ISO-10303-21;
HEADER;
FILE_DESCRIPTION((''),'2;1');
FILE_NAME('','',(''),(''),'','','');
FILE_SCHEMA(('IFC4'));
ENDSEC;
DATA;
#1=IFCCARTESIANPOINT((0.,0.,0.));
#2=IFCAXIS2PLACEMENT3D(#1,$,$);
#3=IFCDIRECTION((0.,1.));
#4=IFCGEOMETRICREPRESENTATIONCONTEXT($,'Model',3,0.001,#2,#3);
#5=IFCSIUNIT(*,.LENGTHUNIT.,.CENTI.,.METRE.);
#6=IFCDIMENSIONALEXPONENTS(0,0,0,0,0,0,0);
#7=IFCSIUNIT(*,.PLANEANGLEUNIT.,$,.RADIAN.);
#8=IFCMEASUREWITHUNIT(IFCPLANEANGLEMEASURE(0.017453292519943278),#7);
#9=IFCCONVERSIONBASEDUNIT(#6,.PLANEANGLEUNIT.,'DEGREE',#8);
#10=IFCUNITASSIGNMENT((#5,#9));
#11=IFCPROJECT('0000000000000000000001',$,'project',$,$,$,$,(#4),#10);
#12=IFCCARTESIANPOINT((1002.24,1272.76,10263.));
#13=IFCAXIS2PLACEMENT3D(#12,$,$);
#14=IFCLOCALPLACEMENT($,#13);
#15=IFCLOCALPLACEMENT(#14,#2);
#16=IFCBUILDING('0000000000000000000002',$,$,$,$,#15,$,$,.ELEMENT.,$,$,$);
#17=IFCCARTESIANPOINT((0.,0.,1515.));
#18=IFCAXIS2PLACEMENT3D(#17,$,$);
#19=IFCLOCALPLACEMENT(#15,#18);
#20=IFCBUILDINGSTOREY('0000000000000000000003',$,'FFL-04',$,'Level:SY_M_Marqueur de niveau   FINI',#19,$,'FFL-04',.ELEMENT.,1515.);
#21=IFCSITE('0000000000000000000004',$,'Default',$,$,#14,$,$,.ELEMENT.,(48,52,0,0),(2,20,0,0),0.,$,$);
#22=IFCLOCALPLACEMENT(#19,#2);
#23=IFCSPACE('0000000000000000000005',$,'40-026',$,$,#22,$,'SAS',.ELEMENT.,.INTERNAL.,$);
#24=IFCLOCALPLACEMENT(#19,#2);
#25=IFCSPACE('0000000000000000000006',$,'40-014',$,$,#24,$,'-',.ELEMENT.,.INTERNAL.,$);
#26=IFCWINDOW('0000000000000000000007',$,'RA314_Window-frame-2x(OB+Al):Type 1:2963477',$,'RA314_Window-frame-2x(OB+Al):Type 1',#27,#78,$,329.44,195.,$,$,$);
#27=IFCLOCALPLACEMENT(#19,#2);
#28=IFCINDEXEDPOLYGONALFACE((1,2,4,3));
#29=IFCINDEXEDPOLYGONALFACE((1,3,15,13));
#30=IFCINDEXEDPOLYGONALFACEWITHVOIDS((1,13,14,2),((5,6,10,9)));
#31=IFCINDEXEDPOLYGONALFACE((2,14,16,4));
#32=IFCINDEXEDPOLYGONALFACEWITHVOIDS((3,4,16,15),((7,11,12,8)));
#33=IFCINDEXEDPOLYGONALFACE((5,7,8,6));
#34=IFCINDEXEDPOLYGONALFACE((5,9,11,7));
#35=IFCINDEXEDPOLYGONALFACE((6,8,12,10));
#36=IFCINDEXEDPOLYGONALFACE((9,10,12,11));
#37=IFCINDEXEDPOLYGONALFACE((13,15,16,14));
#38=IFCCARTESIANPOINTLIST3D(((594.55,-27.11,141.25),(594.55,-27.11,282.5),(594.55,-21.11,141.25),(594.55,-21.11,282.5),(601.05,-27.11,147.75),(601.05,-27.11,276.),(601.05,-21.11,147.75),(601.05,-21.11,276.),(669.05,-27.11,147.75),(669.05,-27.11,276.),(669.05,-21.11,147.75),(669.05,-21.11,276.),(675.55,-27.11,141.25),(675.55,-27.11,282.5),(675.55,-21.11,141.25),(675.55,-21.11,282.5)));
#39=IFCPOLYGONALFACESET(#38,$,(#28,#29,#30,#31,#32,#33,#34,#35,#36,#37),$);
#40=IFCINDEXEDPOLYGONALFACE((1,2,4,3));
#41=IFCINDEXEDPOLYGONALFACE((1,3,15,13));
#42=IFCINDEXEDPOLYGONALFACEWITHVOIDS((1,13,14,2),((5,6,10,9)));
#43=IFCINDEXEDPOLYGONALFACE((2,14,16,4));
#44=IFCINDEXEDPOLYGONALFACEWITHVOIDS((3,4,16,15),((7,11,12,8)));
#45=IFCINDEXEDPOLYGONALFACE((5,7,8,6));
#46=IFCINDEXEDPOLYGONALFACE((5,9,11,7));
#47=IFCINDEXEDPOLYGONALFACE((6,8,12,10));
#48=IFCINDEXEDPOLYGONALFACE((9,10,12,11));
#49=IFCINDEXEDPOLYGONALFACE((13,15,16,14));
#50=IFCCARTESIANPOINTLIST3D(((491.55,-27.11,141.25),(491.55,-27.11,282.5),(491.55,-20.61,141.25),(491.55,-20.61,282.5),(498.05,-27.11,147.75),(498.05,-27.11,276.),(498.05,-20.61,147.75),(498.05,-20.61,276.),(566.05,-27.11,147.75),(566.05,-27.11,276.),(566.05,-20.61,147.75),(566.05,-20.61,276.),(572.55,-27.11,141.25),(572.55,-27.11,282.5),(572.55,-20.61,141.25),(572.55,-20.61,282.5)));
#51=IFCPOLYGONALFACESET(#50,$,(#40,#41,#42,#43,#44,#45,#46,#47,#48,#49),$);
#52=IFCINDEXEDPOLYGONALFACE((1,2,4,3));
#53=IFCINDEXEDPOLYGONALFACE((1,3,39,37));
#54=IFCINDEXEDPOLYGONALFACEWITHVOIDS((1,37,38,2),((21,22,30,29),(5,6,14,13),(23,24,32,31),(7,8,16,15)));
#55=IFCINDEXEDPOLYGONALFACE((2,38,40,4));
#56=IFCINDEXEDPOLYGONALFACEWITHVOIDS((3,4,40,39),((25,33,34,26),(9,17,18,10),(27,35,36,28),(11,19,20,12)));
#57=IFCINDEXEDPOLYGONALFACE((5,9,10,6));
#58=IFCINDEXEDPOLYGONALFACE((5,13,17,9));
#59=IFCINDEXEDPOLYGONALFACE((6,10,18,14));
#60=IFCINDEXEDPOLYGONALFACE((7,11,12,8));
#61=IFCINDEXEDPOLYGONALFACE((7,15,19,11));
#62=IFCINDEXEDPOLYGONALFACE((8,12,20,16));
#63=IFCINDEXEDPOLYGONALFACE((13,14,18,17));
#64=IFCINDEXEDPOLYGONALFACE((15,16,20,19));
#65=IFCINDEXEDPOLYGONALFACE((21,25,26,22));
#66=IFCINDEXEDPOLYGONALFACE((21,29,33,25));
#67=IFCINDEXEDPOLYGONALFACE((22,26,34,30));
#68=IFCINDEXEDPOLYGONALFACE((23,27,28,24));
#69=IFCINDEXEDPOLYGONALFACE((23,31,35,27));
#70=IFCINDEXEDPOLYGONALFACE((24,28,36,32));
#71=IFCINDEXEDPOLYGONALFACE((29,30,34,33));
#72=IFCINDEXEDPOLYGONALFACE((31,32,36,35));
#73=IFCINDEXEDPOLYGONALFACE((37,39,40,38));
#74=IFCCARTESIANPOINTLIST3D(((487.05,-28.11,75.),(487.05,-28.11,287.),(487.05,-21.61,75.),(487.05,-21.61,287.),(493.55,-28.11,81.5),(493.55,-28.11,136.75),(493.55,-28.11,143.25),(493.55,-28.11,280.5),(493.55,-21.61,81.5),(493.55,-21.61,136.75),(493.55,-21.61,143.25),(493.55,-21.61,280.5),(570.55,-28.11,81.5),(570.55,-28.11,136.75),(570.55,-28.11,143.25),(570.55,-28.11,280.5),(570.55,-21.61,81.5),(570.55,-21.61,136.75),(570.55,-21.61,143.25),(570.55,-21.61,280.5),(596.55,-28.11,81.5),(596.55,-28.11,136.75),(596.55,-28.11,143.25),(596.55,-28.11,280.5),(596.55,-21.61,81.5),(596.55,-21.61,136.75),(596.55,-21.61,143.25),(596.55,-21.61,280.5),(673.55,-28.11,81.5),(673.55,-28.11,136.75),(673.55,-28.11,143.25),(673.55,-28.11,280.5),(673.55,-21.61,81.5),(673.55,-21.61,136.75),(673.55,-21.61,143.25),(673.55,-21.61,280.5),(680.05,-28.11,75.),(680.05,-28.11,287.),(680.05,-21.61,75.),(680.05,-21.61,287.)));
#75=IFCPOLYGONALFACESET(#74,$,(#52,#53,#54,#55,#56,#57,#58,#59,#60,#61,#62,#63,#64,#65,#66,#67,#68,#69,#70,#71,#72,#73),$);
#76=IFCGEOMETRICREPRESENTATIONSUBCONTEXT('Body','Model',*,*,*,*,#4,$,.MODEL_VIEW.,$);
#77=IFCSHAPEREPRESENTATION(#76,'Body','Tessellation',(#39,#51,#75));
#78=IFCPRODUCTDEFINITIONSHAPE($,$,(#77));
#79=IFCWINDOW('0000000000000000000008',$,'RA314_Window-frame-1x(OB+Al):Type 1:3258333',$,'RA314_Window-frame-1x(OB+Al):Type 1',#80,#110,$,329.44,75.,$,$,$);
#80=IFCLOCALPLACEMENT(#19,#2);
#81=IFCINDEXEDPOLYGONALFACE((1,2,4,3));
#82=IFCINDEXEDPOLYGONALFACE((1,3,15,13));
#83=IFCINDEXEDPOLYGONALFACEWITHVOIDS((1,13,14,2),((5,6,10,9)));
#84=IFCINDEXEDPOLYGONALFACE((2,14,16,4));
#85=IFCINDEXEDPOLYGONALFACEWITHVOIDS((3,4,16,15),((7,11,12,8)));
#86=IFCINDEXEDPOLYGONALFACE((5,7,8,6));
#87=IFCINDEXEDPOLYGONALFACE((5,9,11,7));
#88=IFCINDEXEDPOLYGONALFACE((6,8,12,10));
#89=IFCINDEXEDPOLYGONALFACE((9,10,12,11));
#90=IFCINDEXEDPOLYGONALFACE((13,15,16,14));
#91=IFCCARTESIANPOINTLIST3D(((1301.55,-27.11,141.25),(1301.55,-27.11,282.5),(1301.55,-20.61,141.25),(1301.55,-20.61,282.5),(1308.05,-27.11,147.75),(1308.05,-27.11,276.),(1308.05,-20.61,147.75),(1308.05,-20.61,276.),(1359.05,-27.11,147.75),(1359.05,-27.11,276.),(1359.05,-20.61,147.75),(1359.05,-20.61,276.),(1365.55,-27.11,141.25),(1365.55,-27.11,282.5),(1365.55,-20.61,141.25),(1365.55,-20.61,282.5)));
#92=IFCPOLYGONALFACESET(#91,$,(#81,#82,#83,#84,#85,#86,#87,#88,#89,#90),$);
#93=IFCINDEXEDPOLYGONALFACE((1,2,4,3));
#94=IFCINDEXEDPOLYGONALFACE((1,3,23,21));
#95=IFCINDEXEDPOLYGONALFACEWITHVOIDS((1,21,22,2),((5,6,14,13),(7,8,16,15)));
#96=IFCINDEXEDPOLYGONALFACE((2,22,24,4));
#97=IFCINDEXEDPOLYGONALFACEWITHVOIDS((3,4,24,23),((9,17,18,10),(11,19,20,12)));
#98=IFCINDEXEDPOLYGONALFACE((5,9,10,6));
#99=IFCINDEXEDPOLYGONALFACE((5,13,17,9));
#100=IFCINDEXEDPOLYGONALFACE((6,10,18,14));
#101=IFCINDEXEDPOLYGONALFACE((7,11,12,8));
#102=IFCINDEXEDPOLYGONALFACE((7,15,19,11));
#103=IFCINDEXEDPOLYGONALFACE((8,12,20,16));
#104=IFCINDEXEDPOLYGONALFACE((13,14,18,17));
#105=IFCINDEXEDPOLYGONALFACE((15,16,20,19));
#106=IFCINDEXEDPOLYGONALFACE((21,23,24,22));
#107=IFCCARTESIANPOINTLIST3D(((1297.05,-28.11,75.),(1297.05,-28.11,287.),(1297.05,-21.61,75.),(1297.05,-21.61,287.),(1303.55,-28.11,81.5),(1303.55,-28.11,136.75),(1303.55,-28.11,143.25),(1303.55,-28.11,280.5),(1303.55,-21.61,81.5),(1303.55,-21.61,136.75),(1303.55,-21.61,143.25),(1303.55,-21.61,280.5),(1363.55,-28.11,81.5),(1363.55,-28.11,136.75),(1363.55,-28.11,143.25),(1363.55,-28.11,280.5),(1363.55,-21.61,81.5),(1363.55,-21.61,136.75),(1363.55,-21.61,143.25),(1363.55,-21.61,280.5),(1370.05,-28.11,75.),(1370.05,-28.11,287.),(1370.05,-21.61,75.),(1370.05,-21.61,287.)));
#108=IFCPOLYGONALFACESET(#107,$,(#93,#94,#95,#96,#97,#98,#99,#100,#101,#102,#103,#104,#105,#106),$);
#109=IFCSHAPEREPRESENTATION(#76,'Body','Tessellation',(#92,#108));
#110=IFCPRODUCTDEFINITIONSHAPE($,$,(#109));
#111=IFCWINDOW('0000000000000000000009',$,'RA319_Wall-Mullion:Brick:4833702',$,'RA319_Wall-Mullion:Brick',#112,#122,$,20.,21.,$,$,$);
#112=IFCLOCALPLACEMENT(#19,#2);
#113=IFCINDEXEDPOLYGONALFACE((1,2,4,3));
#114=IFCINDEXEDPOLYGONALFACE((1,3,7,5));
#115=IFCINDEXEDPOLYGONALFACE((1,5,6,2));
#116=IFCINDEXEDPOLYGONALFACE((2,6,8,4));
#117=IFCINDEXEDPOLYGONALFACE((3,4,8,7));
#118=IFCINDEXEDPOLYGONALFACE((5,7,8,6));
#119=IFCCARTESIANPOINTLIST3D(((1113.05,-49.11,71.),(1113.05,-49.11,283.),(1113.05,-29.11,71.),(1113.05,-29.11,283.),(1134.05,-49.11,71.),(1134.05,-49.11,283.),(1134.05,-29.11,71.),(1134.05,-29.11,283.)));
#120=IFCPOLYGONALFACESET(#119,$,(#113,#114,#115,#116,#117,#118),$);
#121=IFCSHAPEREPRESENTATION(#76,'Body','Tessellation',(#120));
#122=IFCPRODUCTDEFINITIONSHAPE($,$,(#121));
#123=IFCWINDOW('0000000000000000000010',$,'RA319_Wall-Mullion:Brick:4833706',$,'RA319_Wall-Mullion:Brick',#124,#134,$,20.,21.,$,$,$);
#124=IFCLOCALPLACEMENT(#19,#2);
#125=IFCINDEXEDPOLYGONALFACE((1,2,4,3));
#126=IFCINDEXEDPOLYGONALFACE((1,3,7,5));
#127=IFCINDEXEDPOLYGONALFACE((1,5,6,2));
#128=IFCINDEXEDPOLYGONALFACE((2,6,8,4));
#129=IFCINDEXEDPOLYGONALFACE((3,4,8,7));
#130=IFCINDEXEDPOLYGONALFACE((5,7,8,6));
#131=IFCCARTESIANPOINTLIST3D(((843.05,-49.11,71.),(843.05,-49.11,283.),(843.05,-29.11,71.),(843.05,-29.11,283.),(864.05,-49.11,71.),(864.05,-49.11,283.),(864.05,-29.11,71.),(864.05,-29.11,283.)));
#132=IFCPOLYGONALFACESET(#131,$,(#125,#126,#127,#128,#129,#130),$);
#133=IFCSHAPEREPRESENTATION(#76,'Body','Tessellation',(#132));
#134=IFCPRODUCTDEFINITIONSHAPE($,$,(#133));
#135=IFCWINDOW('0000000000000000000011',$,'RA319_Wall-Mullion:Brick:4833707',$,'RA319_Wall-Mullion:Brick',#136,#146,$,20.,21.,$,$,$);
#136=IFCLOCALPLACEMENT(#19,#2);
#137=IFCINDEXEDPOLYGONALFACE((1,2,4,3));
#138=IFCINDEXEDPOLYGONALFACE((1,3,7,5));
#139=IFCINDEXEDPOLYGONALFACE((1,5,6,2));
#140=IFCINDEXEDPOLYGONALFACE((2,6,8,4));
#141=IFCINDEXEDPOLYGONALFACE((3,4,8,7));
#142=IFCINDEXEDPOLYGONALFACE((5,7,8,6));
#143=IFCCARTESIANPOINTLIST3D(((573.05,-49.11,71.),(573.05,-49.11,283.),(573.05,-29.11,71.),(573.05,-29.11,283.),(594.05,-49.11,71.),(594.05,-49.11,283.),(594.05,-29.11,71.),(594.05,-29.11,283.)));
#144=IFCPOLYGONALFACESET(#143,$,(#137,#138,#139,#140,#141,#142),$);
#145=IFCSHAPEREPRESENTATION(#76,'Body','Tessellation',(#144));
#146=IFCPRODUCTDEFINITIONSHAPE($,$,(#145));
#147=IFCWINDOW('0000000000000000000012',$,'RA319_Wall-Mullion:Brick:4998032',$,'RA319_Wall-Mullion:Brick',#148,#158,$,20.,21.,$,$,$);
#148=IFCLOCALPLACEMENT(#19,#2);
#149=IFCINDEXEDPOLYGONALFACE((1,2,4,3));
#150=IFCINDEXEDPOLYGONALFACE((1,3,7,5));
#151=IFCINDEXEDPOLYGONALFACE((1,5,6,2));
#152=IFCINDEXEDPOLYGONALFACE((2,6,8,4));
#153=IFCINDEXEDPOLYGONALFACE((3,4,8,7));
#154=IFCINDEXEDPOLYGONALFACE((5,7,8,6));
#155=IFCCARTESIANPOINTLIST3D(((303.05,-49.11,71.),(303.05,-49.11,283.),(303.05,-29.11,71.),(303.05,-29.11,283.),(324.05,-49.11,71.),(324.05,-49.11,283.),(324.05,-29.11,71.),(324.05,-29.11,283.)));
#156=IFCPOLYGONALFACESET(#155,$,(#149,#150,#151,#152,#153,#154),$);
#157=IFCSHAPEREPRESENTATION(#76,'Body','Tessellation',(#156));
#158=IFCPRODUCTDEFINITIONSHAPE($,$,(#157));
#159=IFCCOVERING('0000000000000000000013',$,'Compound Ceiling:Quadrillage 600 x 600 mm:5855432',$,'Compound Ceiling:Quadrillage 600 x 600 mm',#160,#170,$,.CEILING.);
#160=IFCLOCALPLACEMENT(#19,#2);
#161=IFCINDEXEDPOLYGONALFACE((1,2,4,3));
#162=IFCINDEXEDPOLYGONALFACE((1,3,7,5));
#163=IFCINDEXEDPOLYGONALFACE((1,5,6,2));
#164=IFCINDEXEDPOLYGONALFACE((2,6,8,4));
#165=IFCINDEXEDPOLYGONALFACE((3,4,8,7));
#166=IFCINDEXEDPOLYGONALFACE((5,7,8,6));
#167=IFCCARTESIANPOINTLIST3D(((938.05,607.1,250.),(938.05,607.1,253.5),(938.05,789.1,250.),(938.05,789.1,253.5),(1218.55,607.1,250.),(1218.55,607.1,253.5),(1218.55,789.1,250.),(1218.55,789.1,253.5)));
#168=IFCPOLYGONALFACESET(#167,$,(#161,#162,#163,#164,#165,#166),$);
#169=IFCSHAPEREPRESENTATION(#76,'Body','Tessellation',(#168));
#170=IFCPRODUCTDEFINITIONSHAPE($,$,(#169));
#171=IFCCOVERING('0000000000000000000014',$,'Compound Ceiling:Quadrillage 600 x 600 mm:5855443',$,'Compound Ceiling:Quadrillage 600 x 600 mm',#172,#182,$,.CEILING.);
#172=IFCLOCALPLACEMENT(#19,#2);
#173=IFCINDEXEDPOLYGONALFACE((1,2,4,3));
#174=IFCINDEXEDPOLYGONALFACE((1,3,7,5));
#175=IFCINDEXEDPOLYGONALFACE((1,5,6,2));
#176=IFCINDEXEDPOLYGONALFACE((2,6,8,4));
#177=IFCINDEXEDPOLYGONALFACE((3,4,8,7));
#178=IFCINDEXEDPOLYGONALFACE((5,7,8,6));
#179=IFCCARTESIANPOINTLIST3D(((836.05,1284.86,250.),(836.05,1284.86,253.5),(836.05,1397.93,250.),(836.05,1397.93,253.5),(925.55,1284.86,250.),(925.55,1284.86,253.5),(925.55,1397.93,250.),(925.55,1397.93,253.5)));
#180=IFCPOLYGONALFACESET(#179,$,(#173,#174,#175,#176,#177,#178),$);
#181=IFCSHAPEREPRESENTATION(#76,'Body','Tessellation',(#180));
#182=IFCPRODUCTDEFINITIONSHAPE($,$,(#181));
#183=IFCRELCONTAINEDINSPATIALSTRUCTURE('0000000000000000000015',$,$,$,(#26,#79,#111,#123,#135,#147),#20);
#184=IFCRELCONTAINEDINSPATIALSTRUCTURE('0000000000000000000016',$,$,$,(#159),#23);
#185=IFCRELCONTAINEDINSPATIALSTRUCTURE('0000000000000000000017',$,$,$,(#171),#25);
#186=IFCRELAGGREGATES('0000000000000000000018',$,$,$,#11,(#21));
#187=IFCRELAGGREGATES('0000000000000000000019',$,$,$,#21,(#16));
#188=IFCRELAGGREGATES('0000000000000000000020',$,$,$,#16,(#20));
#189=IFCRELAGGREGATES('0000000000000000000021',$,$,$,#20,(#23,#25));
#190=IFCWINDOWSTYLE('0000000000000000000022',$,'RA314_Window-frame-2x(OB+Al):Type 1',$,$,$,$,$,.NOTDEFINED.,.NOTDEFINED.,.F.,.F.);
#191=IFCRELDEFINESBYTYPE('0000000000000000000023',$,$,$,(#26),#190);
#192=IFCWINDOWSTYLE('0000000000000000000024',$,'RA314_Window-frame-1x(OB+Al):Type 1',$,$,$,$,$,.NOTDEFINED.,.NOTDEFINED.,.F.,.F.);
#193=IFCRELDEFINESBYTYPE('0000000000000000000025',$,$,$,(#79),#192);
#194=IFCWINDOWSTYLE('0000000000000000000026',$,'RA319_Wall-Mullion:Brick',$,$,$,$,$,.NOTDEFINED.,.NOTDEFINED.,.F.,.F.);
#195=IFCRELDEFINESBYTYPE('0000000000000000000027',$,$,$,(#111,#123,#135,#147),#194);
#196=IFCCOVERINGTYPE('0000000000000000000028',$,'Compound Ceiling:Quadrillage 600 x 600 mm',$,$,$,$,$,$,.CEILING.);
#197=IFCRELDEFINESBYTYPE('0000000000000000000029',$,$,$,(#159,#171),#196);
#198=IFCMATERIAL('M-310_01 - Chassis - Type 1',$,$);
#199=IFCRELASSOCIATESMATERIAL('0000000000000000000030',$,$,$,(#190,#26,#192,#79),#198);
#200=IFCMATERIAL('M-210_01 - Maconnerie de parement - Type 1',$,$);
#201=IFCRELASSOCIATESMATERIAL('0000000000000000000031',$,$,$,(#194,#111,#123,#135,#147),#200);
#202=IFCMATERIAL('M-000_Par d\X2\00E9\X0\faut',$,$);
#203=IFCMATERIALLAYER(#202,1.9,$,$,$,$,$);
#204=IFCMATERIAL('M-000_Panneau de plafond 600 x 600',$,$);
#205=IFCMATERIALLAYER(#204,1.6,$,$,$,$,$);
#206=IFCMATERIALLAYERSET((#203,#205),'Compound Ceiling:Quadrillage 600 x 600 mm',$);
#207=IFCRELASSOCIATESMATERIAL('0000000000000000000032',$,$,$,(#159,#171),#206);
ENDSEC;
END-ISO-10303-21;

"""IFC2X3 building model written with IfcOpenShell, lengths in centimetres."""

from ifc_helpers import new_model, entity, si_unit, converted_unit, direction, frame, frame_2d, origin, origin_2d_with_axis, place, context, subcontext, project, spatial, polyline, rectangle, outline, extrude, source, transform, mapped, material, layer, layer_set, layer_usage, type_object, type_shapes, element, save


model = new_model("IFC2X3")

# Units and contexts
model_context = context("Model", 3, precision=0.001, world=origin(), true_north=direction((0.0, 1.0)))
body_context = subcontext(model_context, "Body", "Model", "MODEL_VIEW")
ifc_project = project(units=[si_unit("LENGTHUNIT", "METRE", prefix="CENTI"), converted_unit("PLANEANGLEUNIT", "DEGREE", entity("IfcPlaneAngleMeasure", 0.017453292519943278), si_unit("PLANEANGLEUNIT", "RADIAN"), dimensions=[0, 0, 0, 0, 0, 0, 0])], contexts=[model_context])

# Site, building, storey
site_placement = place(None, frame((1002.24, 1272.76, 10263.0)))
site = spatial("IfcSite", under=ifc_project, at=site_placement, Name="Default", CompositionType="ELEMENT", RefLatitude=(48, 52, 0, 0), RefLongitude=(2, 20, 0, 0), RefElevation=0.0)
building_placement = place(site_placement, origin())
building = spatial("IfcBuilding", under=site, at=building_placement, CompositionType="ELEMENT")
storey_placement = place(building_placement, frame((0.0, 0.0, 1515.0)))
storey = spatial("IfcBuildingStorey", under=building, at=storey_placement, Name="FFL-04", ObjectType="Level:SY_M_Marqueur de niveau   FINI", LongName="FFL-04", CompositionType="ELEMENT", Elevation=1515.0)

# Windows
ifc_material_1 = material(Name="M-310_01 - Chassis - Type 1")
window_style_1 = type_object("IfcWindowStyle", Name="RA314_Window-frame-2x(OB+Al):Type 1", ConstructionType="NOTDEFINED", OperationType="NOTDEFINED", ParameterTakesPrecedence=False, Sizeable=False, material=ifc_material_1)
shared_shape_1 = source(origin(), body_context, "Body", "SweptSolid", [
    extrude(outline(polyline([(-70.62, -40.5), (70.62, -40.5), (70.62, 40.5), (-70.62, 40.5), (-70.62, -40.5)]), holes=[polyline([(-64.12, -34.0), (-64.12, 34.0), (64.12, 34.0), (64.12, -34.0), (-64.12, -34.0)])]), frame((51.5, 1.0, 136.87), z_axis=(0.0, 1.0, 0.0), x_axis=(0.0, 0.0, -1.0)), (0.0, 0.0, 1.0), 6.0),
    extrude(outline(polyline([(-70.62, -40.5), (70.62, -40.5), (70.62, 40.5), (-70.62, 40.5), (-70.62, -40.5)]), holes=[polyline([(-64.12, -34.0), (-64.12, 34.0), (64.12, 34.0), (64.12, -34.0), (-64.12, -34.0)])]), frame((-51.5, 1.0, 136.87), z_axis=(0.0, 1.0, 0.0), x_axis=(0.0, 0.0, -1.0)), (0.0, 0.0, 1.0), 6.5),
    extrude(outline(polyline([(-106.0, -96.5), (106.0, -96.5), (106.0, 96.5), (-106.0, 96.5), (-106.0, -96.5)]), holes=[polyline([(44.25, 13.0), (44.25, 90.0), (99.5, 90.0), (99.5, 13.0), (44.25, 13.0)]), polyline([(44.25, -90.0), (44.25, -13.0), (99.5, -13.0), (99.5, -90.0), (44.25, -90.0)]), polyline([(-99.5, -90.0), (-99.5, -13.0), (37.75, -13.0), (37.75, -90.0), (-99.5, -90.0)]), polyline([(-99.5, 13.0), (-99.5, 90.0), (37.75, 90.0), (37.75, 13.0), (-99.5, 13.0)])]), frame((0.0, 0.0, 106.0), z_axis=(0.0, 1.0, 0.0), x_axis=(0.0, 0.0, -1.0)), (0.0, 0.0, 1.0), 6.5),
])
type_shapes(window_style_1, [shared_shape_1])
window_1_placement = place(storey_placement, frame((583.55, -28.11, 75.0)))
element("IfcWindow", 1, at=window_1_placement, inside=storey, type_object=window_style_1, material=ifc_material_1, Name="RA314_Window-frame-2x(OB+Al):Type 1:2963477", ObjectType="RA314_Window-frame-2x(OB+Al):Type 1", OverallHeight=329.44, OverallWidth=195.0, context=body_context, shape_type="MappedRepresentation", body=[
    mapped(shared_shape_1, transform((0.0, 0.0, 0.0), scale=1.0)),
])
window_style_2 = type_object("IfcWindowStyle", Name="RA314_Window-frame-1x(OB+Al):Type 1", ConstructionType="NOTDEFINED", OperationType="NOTDEFINED", ParameterTakesPrecedence=False, Sizeable=False, material=ifc_material_1)
shared_shape_2 = source(origin(), body_context, "Body", "SweptSolid", [
    extrude(outline(polyline([(-70.62, -32.0), (70.62, -32.0), (70.62, 32.0), (-70.62, 32.0), (-70.62, -32.0)]), holes=[polyline([(-64.12, -25.5), (-64.12, 25.5), (64.12, 25.5), (64.12, -25.5), (-64.12, -25.5)])]), frame((0.0, -7.5, 136.87), z_axis=(0.0, 1.0, 0.0), x_axis=(0.0, 0.0, -1.0)), (0.0, 0.0, 1.0), 6.5),
    extrude(outline(polyline([(-106.0, -36.5), (106.0, -36.5), (106.0, 36.5), (-106.0, 36.5), (-106.0, -36.5)]), holes=[polyline([(-99.5, -30.0), (-99.5, 30.0), (37.75, 30.0), (37.75, -30.0), (-99.5, -30.0)]), polyline([(44.25, -30.0), (44.25, 30.0), (99.5, 30.0), (99.5, -30.0), (44.25, -30.0)])]), frame((0.0, -6.5, 106.0), z_axis=(0.0, 1.0, 0.0), x_axis=(0.0, 0.0, -1.0)), (0.0, 0.0, 1.0), 6.5),
])
type_shapes(window_style_2, [shared_shape_2])
window_2_placement = place(storey_placement, frame((1333.55, -28.11, 75.0), z_axis=(0.0, 0.0, 1.0), x_axis=(-1.0, 0.0, 0.0)))
element("IfcWindow", 2, at=window_2_placement, inside=storey, type_object=window_style_2, material=ifc_material_1, Name="RA314_Window-frame-1x(OB+Al):Type 1:3258333", ObjectType="RA314_Window-frame-1x(OB+Al):Type 1", OverallHeight=329.44, OverallWidth=75.0, context=body_context, shape_type="MappedRepresentation", body=[
    mapped(shared_shape_2, transform((0.0, 0.0, 0.0), scale=1.0)),
])
ifc_material_2 = material(Name="M-210_01 - Maconnerie de parement - Type 1")
window_style_3 = type_object("IfcWindowStyle", Name="RA319_Wall-Mullion:Brick", ConstructionType="NOTDEFINED", OperationType="NOTDEFINED", ParameterTakesPrecedence=False, Sizeable=False, material=ifc_material_2)
shared_shape_3 = source(origin(), body_context, "Body", "SweptSolid", [
    extrude(rectangle(XDim=21.0, YDim=20.0, at=origin_2d_with_axis()), frame((0.0, 10.0, -4.0), z_axis=(0.0, 0.0, 1.0), x_axis=(-1.0, 0.0, 0.0)), (0.0, 0.0, 1.0), 212.0),
])
type_shapes(window_style_3, [shared_shape_3])
for number, where, z_axis, x_axis, name in (
    (3, (1123.55, -29.11, 75.0), (0.0, 0.0, 1.0), (-1.0, 0.0, 0.0), "RA319_Wall-Mullion:Brick:4833702"),
    (4, (853.55, -29.11, 75.0), (0.0, 0.0, 1.0), (-1.0, 0.0, 0.0), "RA319_Wall-Mullion:Brick:4833706"),
    (5, (583.55, -29.11, 75.0), (0.0, 0.0, 1.0), (-1.0, 0.0, 0.0), "RA319_Wall-Mullion:Brick:4833707"),
    (6, (313.55, -29.11, 75.0), (0.0, 0.0, 1.0), (-1.0, 0.0, 0.0), "RA319_Wall-Mullion:Brick:4998032"),
):
    element("IfcWindow", number, at=place(storey_placement, frame(where, z_axis=z_axis, x_axis=x_axis)), inside=storey, type_object=window_style_3, material=ifc_material_2, Name=name, ObjectType="RA319_Wall-Mullion:Brick", OverallHeight=20.0, OverallWidth=21.0, context=body_context, shape_type="MappedRepresentation", body=[
        mapped(shared_shape_3, transform((0.0, 0.0, 0.0), scale=1.0)),
    ])

# Shared definitions
ifc_material_3 = material(Name="M-000_Par défaut")
ifc_layer_1 = layer(ifc_material_3, 1.9)
ifc_material_4 = material(Name="M-000_Panneau de plafond 600 x 600")
ifc_layer_2 = layer(ifc_material_4, 1.6)
ifc_layer_set_1 = layer_set([ifc_layer_1, ifc_layer_2], Name="Compound Ceiling:Quadrillage 600 x 600 mm")
covering_type_1 = type_object("IfcCoveringType", Name="Compound Ceiling:Quadrillage 600 x 600 mm", PredefinedType="CEILING")

# Shared definitions
space_1_placement = place(storey_placement, origin())
space_1 = spatial("IfcSpace", under=storey, at=space_1_placement, Name="40-026", LongName="SAS", CompositionType="ELEMENT", InteriorOrExteriorSpace="INTERNAL")

# Covering
ifc_layer_usage_1 = layer_usage(ifc_layer_set_1, "AXIS3", "NEGATIVE", 3.5)
covering_1_placement = place(space_1_placement, origin())
element("IfcCovering", 7, at=covering_1_placement, inside=space_1, type_object=covering_type_1, material=ifc_layer_usage_1, Name="Compound Ceiling:Quadrillage 600 x 600 mm:5855432", ObjectType="Compound Ceiling:Quadrillage 600 x 600 mm", PredefinedType="CEILING", context=body_context, shape_type="SweptSolid", body=[
    extrude(rectangle(XDim=182.0, YDim=280.5, at=frame_2d((0.0, 29.33), x_axis=(1.0, 0.0))), frame((1048.97, 698.1, 250.0), z_axis=(0.0, 0.0, 1.0), x_axis=(0.0, -1.0, 0.0)), (0.0, 0.0, 1.0), 3.5),
])

# Shared definitions
space_2_placement = place(storey_placement, origin())
space_2 = spatial("IfcSpace", under=storey, at=space_2_placement, Name="40-014", LongName="-", CompositionType="ELEMENT", InteriorOrExteriorSpace="INTERNAL")

# Covering
ifc_layer_usage_2 = layer_usage(ifc_layer_set_1, "AXIS3", "NEGATIVE", 3.5)
covering_2_placement = place(space_2_placement, origin())
element("IfcCovering", 8, at=covering_2_placement, inside=space_2, type_object=covering_type_1, material=ifc_layer_usage_2, Name="Compound Ceiling:Quadrillage 600 x 600 mm:5855443", ObjectType="Compound Ceiling:Quadrillage 600 x 600 mm", PredefinedType="CEILING", context=body_context, shape_type="SweptSolid", body=[
    extrude(rectangle(XDim=113.07, YDim=89.49, at=frame_2d((0.0, 0.0), x_axis=(1.0, 0.0))), frame((880.8, 1341.39, 250.0), z_axis=(0.0, 0.0, 1.0), x_axis=(0.0, -1.0, 0.0)), (0.0, 0.0, 1.0), 3.5),
])

save(model, "model.ifc")
